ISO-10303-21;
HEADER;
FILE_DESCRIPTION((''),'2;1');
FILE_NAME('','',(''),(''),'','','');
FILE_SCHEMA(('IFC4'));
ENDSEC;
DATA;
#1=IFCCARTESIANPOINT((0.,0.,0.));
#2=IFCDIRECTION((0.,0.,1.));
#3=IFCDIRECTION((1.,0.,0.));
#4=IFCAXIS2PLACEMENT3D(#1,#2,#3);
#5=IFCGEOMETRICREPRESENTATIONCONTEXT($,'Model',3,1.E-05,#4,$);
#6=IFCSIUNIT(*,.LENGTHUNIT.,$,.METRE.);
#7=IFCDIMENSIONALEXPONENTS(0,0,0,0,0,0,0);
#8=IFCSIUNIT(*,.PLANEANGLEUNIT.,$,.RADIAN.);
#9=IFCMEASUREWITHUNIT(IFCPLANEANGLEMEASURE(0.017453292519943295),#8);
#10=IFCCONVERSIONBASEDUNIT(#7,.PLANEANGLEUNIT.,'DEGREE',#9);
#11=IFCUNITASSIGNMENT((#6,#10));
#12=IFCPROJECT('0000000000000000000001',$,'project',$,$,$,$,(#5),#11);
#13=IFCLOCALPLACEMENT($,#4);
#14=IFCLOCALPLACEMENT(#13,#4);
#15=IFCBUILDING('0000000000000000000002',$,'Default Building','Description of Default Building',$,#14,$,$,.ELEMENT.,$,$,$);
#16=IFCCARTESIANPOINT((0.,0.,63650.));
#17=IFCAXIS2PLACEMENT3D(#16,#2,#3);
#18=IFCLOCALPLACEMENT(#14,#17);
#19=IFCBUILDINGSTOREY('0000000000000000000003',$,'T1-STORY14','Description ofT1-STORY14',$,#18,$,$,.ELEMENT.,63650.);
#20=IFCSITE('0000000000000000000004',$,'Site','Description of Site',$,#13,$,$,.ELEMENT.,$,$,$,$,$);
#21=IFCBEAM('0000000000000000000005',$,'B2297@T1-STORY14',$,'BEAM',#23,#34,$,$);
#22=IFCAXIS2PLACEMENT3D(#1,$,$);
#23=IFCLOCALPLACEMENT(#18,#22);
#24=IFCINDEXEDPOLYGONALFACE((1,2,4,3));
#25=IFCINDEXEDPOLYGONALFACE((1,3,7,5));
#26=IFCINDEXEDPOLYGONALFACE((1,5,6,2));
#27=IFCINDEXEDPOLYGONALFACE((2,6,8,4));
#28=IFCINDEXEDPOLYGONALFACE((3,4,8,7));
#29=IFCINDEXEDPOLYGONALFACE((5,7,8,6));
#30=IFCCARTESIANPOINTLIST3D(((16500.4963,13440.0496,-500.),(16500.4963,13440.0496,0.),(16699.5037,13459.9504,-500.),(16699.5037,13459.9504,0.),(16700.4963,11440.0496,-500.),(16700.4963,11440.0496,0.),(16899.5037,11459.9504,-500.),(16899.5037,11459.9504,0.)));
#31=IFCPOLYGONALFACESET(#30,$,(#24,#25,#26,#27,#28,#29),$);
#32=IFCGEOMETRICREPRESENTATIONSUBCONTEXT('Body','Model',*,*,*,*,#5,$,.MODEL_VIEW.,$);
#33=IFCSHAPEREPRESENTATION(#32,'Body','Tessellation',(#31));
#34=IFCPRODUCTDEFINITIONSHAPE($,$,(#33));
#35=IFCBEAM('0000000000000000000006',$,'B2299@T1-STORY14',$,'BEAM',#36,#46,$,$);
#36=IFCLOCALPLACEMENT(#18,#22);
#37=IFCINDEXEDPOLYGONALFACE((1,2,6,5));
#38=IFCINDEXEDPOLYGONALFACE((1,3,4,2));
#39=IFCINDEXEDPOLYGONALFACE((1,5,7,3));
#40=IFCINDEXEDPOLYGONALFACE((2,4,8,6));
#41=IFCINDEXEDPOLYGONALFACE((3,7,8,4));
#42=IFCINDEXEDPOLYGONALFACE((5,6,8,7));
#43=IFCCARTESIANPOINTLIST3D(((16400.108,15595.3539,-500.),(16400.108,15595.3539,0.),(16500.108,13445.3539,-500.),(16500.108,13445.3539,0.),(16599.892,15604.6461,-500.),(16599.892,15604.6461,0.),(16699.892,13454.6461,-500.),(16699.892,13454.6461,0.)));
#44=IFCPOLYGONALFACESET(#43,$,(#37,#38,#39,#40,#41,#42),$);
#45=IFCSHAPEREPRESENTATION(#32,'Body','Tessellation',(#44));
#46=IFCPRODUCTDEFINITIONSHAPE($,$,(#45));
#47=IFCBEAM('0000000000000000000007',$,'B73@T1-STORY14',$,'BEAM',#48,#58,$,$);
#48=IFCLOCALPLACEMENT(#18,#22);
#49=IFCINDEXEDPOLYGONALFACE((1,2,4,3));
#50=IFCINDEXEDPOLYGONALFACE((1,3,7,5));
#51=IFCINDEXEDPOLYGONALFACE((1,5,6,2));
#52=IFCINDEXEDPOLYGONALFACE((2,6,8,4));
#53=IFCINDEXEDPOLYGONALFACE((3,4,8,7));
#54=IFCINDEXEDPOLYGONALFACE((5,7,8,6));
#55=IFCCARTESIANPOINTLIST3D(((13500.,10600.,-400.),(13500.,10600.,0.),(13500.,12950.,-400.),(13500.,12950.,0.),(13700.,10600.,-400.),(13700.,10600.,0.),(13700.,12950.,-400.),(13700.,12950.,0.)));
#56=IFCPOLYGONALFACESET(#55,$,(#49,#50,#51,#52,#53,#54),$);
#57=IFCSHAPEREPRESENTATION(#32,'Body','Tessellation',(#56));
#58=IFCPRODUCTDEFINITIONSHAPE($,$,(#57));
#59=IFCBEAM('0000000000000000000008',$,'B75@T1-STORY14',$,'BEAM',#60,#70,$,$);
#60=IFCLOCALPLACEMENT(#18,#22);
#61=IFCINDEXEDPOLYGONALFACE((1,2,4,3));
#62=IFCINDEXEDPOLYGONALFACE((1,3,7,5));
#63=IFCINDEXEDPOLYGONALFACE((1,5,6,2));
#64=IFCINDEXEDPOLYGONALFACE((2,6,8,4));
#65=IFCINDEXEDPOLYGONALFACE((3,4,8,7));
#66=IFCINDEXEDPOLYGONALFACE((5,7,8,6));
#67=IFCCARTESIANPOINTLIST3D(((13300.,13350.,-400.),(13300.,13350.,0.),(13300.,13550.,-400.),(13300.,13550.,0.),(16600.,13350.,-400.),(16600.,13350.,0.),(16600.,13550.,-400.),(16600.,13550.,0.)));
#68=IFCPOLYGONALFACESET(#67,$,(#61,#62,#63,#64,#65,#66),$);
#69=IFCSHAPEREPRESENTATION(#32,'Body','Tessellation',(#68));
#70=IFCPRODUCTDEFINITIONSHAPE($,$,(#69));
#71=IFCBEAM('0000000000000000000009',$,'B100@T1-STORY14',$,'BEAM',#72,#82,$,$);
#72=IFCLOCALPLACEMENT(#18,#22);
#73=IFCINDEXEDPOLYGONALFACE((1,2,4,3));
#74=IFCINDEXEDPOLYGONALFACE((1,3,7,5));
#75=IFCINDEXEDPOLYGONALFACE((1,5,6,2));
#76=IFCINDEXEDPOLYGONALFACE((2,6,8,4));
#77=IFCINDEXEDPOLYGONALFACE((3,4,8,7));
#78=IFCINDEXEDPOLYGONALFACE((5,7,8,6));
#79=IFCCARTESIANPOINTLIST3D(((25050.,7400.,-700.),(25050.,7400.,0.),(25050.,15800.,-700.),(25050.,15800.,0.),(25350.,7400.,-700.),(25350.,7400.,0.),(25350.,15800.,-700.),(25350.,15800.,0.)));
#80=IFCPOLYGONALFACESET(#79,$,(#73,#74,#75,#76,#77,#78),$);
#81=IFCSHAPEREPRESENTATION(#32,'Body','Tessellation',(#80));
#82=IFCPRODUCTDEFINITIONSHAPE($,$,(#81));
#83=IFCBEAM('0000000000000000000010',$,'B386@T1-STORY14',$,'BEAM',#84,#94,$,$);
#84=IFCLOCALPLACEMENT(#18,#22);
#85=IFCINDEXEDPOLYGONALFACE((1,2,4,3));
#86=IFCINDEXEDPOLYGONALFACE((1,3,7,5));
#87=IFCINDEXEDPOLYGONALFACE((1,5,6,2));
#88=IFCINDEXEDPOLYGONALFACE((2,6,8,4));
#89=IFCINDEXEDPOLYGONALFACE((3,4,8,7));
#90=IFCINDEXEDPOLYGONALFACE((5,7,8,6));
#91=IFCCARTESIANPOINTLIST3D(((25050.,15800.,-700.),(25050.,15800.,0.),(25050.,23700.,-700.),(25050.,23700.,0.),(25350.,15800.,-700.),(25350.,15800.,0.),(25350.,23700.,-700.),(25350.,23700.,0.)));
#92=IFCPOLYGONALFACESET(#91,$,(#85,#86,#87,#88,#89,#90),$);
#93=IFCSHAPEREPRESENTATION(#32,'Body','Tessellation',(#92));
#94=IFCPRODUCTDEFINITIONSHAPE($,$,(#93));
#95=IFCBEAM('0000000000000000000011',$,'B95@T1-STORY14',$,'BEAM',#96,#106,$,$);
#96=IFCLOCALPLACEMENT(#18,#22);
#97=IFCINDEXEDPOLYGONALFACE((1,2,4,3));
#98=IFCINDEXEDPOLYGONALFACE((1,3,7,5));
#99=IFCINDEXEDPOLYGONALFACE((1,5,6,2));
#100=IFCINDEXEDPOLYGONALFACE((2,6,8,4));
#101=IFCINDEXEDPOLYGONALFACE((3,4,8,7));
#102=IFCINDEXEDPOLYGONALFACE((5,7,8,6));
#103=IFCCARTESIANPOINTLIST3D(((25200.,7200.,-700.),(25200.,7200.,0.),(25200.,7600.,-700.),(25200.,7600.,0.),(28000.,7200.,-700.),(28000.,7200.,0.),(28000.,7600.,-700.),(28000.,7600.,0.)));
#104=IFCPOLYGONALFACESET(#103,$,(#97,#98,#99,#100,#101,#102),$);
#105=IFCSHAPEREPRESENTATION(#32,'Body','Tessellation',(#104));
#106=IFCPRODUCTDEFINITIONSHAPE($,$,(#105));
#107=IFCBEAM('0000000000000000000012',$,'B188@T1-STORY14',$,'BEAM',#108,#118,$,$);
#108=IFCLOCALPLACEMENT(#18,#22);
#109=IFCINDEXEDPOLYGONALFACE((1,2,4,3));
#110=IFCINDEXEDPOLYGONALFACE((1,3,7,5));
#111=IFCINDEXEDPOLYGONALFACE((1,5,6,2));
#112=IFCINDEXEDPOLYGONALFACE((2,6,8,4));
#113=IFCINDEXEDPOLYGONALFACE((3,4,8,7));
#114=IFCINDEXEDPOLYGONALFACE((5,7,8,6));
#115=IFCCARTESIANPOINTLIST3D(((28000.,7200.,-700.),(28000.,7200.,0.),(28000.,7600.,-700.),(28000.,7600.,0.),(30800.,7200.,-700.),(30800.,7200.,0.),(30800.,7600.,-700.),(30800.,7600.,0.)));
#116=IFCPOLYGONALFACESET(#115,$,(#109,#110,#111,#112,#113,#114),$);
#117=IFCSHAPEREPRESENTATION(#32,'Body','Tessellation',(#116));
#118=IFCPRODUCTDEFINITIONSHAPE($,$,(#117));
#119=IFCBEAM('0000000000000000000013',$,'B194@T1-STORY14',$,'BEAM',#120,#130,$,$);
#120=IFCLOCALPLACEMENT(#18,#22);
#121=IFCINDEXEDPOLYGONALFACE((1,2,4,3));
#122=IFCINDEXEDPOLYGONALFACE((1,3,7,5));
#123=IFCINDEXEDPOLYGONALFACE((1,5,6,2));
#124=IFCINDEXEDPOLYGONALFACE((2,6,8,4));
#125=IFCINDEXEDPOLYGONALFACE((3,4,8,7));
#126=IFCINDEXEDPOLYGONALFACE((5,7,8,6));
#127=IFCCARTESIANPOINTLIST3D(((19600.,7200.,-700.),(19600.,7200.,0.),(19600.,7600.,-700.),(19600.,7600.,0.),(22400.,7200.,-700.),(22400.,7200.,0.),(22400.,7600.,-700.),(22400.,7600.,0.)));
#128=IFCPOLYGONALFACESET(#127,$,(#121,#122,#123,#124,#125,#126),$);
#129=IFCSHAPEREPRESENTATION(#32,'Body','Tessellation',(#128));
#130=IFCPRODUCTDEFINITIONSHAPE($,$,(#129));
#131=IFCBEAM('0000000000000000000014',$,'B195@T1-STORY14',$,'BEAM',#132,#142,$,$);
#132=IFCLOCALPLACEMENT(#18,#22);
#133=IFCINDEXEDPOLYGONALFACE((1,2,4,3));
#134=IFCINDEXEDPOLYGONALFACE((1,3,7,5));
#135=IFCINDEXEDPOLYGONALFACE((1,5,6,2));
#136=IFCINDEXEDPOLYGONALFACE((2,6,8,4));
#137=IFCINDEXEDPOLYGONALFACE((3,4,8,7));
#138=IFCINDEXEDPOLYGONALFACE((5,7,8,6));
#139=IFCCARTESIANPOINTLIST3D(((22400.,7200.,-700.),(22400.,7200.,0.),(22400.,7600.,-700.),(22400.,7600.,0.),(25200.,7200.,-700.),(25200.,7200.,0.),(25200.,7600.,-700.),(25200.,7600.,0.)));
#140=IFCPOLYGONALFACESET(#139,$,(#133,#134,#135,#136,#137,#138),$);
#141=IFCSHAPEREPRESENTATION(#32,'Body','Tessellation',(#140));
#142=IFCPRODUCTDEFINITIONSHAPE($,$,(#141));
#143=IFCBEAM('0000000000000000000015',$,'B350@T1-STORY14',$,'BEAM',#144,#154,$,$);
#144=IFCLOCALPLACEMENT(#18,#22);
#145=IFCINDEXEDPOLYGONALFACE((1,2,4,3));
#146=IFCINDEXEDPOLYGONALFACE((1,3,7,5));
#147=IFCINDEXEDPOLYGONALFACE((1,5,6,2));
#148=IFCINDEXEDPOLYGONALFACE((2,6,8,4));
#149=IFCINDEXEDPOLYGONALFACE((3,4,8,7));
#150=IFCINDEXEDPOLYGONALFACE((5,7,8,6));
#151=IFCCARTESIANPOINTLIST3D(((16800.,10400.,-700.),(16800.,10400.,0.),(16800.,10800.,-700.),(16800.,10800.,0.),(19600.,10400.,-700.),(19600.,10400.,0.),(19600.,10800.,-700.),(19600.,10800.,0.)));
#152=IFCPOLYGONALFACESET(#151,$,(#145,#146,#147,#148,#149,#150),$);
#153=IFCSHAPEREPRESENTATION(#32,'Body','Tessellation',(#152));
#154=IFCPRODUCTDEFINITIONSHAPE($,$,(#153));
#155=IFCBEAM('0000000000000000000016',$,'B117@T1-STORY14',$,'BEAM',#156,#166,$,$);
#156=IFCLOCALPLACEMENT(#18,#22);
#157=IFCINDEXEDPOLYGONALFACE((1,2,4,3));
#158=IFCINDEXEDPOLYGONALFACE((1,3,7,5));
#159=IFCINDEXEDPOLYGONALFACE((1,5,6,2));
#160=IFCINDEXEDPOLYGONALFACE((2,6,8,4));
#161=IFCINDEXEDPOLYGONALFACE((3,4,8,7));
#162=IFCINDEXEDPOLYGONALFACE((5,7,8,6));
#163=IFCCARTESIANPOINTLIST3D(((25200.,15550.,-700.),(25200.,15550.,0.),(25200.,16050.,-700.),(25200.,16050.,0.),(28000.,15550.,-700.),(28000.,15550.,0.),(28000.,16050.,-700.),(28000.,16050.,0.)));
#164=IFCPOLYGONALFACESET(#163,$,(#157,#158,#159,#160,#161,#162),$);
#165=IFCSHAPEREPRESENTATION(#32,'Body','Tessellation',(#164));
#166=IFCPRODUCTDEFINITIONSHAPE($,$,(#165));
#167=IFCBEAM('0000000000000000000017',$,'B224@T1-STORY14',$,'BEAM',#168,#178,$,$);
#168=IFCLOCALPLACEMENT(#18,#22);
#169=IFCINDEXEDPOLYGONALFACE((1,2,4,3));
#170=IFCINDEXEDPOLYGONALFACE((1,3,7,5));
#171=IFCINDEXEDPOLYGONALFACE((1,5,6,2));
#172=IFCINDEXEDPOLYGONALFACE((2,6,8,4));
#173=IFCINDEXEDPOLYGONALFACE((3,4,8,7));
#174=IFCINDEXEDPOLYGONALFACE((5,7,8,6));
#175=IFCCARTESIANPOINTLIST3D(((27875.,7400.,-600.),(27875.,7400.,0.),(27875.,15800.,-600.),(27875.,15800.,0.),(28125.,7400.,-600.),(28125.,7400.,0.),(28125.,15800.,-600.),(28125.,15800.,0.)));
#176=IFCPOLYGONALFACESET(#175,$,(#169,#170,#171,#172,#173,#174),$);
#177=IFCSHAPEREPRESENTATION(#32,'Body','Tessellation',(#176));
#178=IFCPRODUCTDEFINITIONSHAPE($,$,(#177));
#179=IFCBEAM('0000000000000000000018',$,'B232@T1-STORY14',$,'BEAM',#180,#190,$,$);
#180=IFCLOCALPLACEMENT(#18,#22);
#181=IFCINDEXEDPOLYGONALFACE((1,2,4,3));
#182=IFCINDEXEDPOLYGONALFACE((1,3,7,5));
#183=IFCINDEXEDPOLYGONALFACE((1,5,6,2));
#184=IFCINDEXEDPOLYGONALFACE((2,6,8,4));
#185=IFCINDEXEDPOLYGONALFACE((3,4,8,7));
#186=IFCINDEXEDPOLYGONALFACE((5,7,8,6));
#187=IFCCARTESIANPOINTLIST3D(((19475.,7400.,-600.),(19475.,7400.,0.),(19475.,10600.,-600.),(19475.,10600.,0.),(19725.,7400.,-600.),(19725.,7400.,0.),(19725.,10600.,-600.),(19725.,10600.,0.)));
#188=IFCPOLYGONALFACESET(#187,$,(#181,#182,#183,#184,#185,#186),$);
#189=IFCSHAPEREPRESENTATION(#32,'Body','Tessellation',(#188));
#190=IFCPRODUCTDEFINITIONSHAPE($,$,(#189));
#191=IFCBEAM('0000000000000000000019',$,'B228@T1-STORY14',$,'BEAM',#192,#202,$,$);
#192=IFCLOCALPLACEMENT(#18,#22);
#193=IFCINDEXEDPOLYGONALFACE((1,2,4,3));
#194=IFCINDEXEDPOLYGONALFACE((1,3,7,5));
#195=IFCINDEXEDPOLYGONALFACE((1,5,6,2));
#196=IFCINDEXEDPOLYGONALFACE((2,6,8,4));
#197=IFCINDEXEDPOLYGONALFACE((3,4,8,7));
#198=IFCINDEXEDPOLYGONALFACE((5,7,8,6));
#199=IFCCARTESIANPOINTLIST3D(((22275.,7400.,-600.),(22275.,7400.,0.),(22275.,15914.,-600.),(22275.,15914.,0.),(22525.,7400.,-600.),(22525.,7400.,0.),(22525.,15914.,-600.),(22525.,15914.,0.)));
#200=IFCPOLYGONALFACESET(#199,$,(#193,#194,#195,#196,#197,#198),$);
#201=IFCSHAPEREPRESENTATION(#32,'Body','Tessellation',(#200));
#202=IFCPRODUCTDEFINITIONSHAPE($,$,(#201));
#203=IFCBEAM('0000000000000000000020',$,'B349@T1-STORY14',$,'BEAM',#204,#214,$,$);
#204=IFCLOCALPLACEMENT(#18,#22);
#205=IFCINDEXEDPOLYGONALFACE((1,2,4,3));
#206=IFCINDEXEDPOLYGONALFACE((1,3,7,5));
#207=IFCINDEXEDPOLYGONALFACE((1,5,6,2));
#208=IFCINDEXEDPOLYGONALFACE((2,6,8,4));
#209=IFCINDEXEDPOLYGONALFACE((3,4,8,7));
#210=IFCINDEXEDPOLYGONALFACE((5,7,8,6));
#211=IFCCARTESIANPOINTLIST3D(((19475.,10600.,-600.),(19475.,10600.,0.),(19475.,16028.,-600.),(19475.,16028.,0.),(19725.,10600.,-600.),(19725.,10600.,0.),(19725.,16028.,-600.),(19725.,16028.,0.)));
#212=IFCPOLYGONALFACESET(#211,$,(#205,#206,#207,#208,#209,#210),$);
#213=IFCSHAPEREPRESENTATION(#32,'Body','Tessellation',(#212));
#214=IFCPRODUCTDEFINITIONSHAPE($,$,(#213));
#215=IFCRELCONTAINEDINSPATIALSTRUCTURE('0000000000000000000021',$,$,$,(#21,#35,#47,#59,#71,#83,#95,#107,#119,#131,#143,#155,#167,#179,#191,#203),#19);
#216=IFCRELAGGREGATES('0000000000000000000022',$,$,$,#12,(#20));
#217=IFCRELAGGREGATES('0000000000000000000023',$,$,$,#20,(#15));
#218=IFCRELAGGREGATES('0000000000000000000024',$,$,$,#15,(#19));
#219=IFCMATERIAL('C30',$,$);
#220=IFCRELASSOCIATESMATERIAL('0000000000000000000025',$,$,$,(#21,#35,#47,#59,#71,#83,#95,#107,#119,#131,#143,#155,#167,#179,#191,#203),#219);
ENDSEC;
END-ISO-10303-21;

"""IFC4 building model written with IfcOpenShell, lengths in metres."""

from ifc_helpers import new_model, entity, si_unit, converted_unit, frame, origin_with_axes, place, context, subcontext, project, spatial, rectangle, extrude, material, element, save


model = new_model("IFC4")

# Units and contexts
model_context = context("Model", 3, precision=1e-05, world=origin_with_axes())
body_context = subcontext(model_context, "Body", "Model", "MODEL_VIEW")
ifc_project = project(units=[si_unit("LENGTHUNIT", "METRE"), converted_unit("PLANEANGLEUNIT", "DEGREE", entity("IfcPlaneAngleMeasure", 0.017453292519943295), si_unit("PLANEANGLEUNIT", "RADIAN"), dimensions=[0, 0, 0, 0, 0, 0, 0])], contexts=[model_context])

# Site, building, storey
site_placement = place(None, origin_with_axes())
site = spatial("IfcSite", under=ifc_project, at=site_placement, Name="Site", Description="Description of Site", CompositionType="ELEMENT")
building_placement = place(site_placement, origin_with_axes())
building = spatial("IfcBuilding", under=site, at=building_placement, Name="Default Building", Description="Description of Default Building", CompositionType="ELEMENT")
storey_placement = place(building_placement, frame((0.0, 0.0, 63650.0), z_axis=(0.0, 0.0, 1.0), x_axis=(1.0, 0.0, 0.0)))
storey = spatial("IfcBuildingStorey", under=building, at=storey_placement, Name="T1-STORY14", Description="Description ofT1-STORY14", CompositionType="ELEMENT", Elevation=63650.0)

# Beams
ifc_material_1 = material(Name="C30")
beam_1_placement = place(storey_placement, frame((16600.0, 13450.0, -250.0), z_axis=(0.099504, -0.995037, 0.0), x_axis=(0.995037, 0.099504, 0.0)))
element("IfcBeam", 1, at=beam_1_placement, inside=storey, material=ifc_material_1, Name="B2297@T1-STORY14", ObjectType="BEAM", context=body_context, shape_type="SweptSolid", body=[
    extrude(rectangle(XDim=200.0, YDim=500.0), origin_with_axes(), (0.0, 0.0, 1.0), 2009.9751),
])
beam_2_placement = place(storey_placement, frame((16500.0, 15600.0, -250.0), z_axis=(0.046461, -0.99892, 0.0), x_axis=(0.99892, 0.046461, 0.0)))
element("IfcBeam", 2, at=beam_2_placement, inside=storey, material=ifc_material_1, Name="B2299@T1-STORY14", ObjectType="BEAM", context=body_context, shape_type="SweptSolid", body=[
    extrude(rectangle(XDim=200.0, YDim=500.0), origin_with_axes(), (0.0, 0.0, 1.0), 2152.3243),
])
beam_3_placement = place(storey_placement, frame((13600.0, 10600.0, -200.0), z_axis=(0.0, 1.0, 0.0), x_axis=(-1.0, 0.0, 0.0)))
element("IfcBeam", 3, at=beam_3_placement, inside=storey, material=ifc_material_1, Name="B73@T1-STORY14", ObjectType="BEAM", context=body_context, shape_type="SweptSolid", body=[
    extrude(rectangle(XDim=200.0, YDim=400.0), origin_with_axes(), (0.0, 0.0, 1.0), 2350.0),
])
beam_4_placement = place(storey_placement, frame((13300.0, 13450.0, -200.0), z_axis=(1.0, 0.0, 0.0), x_axis=(0.0, 1.0, 0.0)))
element("IfcBeam", 4, at=beam_4_placement, inside=storey, material=ifc_material_1, Name="B75@T1-STORY14", ObjectType="BEAM", context=body_context, shape_type="SweptSolid", body=[
    extrude(rectangle(XDim=200.0, YDim=400.0), origin_with_axes(), (0.0, 0.0, 1.0), 3300.0),
])
beam_5_placement = place(storey_placement, frame((25200.0, 7400.0, -350.0), z_axis=(0.0, 1.0, 0.0), x_axis=(-1.0, 0.0, 0.0)))
element("IfcBeam", 5, at=beam_5_placement, inside=storey, material=ifc_material_1, Name="B100@T1-STORY14", ObjectType="BEAM", context=body_context, shape_type="SweptSolid", body=[
    extrude(rectangle(XDim=300.0, YDim=700.0), origin_with_axes(), (0.0, 0.0, 1.0), 8400.0),
])
beam_6_placement = place(storey_placement, frame((25200.0, 15800.0, -350.0), z_axis=(0.0, 1.0, 0.0), x_axis=(-1.0, 0.0, 0.0)))
element("IfcBeam", 6, at=beam_6_placement, inside=storey, material=ifc_material_1, Name="B386@T1-STORY14", ObjectType="BEAM", context=body_context, shape_type="SweptSolid", body=[
    extrude(rectangle(XDim=300.0, YDim=700.0), origin_with_axes(), (0.0, 0.0, 1.0), 7900.0),
])
for number, where, z_axis, x_axis, name in (
    (7, (25200.0, 7400.0, -350.0), (1.0, 0.0, 0.0), (0.0, 1.0, 0.0), "B95@T1-STORY14"),
    (8, (28000.0, 7400.0, -350.0), (1.0, 0.0, 0.0), (0.0, 1.0, 0.0), "B188@T1-STORY14"),
    (9, (19600.0, 7400.0, -350.0), (1.0, 0.0, 0.0), (0.0, 1.0, 0.0), "B194@T1-STORY14"),
    (10, (22400.0, 7400.0, -350.0), (1.0, 0.0, 0.0), (0.0, 1.0, 0.0), "B195@T1-STORY14"),
    (11, (16800.0, 10600.0, -350.0), (1.0, 0.0, 0.0), (0.0, 1.0, 0.0), "B350@T1-STORY14"),
):
    element("IfcBeam", number, at=place(storey_placement, frame(where, z_axis=z_axis, x_axis=x_axis)), inside=storey, material=ifc_material_1, Name=name, ObjectType="BEAM", context=body_context, shape_type="SweptSolid", body=[
        extrude(rectangle(XDim=400.0, YDim=700.0), origin_with_axes(), (0.0, 0.0, 1.0), 2800.0),
    ])
beam_7_placement = place(storey_placement, frame((25200.0, 15800.0, -350.0), z_axis=(1.0, 0.0, 0.0), x_axis=(0.0, 1.0, 0.0)))
element("IfcBeam", 12, at=beam_7_placement, inside=storey, material=ifc_material_1, Name="B117@T1-STORY14", ObjectType="BEAM", context=body_context, shape_type="SweptSolid", body=[
    extrude(rectangle(XDim=500.0, YDim=700.0), origin_with_axes(), (0.0, 0.0, 1.0), 2800.0),
])
beam_8_placement = place(storey_placement, frame((28000.0, 7400.0, -300.0), z_axis=(0.0, 1.0, 0.0), x_axis=(-1.0, 0.0, 0.0)))
element("IfcBeam", 13, at=beam_8_placement, inside=storey, material=ifc_material_1, Name="B224@T1-STORY14", ObjectType="BEAM", context=body_context, shape_type="SweptSolid", body=[
    extrude(rectangle(XDim=250.0, YDim=600.0), origin_with_axes(), (0.0, 0.0, 1.0), 8400.0),
])
beam_9_placement = place(storey_placement, frame((19600.0, 7400.0, -300.0), z_axis=(0.0, 1.0, 0.0), x_axis=(-1.0, 0.0, 0.0)))
element("IfcBeam", 14, at=beam_9_placement, inside=storey, material=ifc_material_1, Name="B232@T1-STORY14", ObjectType="BEAM", context=body_context, shape_type="SweptSolid", body=[
    extrude(rectangle(XDim=250.0, YDim=600.0), origin_with_axes(), (0.0, 0.0, 1.0), 3200.0),
])
beam_10_placement = place(storey_placement, frame((22400.0, 7400.0, -300.0), z_axis=(0.0, 1.0, 0.0), x_axis=(-1.0, 0.0, 0.0)))
element("IfcBeam", 15, at=beam_10_placement, inside=storey, material=ifc_material_1, Name="B228@T1-STORY14", ObjectType="BEAM", context=body_context, shape_type="SweptSolid", body=[
    extrude(rectangle(XDim=250.0, YDim=600.0), origin_with_axes(), (0.0, 0.0, 1.0), 8514.0),
])
beam_11_placement = place(storey_placement, frame((19600.0, 10600.0, -300.0), z_axis=(0.0, 1.0, 0.0), x_axis=(-1.0, 0.0, 0.0)))
element("IfcBeam", 16, at=beam_11_placement, inside=storey, material=ifc_material_1, Name="B349@T1-STORY14", ObjectType="BEAM", context=body_context, shape_type="SweptSolid", body=[
    extrude(rectangle(XDim=250.0, YDim=600.0), origin_with_axes(), (0.0, 0.0, 1.0), 5428.0),
])

save(model, "model.ifc")
